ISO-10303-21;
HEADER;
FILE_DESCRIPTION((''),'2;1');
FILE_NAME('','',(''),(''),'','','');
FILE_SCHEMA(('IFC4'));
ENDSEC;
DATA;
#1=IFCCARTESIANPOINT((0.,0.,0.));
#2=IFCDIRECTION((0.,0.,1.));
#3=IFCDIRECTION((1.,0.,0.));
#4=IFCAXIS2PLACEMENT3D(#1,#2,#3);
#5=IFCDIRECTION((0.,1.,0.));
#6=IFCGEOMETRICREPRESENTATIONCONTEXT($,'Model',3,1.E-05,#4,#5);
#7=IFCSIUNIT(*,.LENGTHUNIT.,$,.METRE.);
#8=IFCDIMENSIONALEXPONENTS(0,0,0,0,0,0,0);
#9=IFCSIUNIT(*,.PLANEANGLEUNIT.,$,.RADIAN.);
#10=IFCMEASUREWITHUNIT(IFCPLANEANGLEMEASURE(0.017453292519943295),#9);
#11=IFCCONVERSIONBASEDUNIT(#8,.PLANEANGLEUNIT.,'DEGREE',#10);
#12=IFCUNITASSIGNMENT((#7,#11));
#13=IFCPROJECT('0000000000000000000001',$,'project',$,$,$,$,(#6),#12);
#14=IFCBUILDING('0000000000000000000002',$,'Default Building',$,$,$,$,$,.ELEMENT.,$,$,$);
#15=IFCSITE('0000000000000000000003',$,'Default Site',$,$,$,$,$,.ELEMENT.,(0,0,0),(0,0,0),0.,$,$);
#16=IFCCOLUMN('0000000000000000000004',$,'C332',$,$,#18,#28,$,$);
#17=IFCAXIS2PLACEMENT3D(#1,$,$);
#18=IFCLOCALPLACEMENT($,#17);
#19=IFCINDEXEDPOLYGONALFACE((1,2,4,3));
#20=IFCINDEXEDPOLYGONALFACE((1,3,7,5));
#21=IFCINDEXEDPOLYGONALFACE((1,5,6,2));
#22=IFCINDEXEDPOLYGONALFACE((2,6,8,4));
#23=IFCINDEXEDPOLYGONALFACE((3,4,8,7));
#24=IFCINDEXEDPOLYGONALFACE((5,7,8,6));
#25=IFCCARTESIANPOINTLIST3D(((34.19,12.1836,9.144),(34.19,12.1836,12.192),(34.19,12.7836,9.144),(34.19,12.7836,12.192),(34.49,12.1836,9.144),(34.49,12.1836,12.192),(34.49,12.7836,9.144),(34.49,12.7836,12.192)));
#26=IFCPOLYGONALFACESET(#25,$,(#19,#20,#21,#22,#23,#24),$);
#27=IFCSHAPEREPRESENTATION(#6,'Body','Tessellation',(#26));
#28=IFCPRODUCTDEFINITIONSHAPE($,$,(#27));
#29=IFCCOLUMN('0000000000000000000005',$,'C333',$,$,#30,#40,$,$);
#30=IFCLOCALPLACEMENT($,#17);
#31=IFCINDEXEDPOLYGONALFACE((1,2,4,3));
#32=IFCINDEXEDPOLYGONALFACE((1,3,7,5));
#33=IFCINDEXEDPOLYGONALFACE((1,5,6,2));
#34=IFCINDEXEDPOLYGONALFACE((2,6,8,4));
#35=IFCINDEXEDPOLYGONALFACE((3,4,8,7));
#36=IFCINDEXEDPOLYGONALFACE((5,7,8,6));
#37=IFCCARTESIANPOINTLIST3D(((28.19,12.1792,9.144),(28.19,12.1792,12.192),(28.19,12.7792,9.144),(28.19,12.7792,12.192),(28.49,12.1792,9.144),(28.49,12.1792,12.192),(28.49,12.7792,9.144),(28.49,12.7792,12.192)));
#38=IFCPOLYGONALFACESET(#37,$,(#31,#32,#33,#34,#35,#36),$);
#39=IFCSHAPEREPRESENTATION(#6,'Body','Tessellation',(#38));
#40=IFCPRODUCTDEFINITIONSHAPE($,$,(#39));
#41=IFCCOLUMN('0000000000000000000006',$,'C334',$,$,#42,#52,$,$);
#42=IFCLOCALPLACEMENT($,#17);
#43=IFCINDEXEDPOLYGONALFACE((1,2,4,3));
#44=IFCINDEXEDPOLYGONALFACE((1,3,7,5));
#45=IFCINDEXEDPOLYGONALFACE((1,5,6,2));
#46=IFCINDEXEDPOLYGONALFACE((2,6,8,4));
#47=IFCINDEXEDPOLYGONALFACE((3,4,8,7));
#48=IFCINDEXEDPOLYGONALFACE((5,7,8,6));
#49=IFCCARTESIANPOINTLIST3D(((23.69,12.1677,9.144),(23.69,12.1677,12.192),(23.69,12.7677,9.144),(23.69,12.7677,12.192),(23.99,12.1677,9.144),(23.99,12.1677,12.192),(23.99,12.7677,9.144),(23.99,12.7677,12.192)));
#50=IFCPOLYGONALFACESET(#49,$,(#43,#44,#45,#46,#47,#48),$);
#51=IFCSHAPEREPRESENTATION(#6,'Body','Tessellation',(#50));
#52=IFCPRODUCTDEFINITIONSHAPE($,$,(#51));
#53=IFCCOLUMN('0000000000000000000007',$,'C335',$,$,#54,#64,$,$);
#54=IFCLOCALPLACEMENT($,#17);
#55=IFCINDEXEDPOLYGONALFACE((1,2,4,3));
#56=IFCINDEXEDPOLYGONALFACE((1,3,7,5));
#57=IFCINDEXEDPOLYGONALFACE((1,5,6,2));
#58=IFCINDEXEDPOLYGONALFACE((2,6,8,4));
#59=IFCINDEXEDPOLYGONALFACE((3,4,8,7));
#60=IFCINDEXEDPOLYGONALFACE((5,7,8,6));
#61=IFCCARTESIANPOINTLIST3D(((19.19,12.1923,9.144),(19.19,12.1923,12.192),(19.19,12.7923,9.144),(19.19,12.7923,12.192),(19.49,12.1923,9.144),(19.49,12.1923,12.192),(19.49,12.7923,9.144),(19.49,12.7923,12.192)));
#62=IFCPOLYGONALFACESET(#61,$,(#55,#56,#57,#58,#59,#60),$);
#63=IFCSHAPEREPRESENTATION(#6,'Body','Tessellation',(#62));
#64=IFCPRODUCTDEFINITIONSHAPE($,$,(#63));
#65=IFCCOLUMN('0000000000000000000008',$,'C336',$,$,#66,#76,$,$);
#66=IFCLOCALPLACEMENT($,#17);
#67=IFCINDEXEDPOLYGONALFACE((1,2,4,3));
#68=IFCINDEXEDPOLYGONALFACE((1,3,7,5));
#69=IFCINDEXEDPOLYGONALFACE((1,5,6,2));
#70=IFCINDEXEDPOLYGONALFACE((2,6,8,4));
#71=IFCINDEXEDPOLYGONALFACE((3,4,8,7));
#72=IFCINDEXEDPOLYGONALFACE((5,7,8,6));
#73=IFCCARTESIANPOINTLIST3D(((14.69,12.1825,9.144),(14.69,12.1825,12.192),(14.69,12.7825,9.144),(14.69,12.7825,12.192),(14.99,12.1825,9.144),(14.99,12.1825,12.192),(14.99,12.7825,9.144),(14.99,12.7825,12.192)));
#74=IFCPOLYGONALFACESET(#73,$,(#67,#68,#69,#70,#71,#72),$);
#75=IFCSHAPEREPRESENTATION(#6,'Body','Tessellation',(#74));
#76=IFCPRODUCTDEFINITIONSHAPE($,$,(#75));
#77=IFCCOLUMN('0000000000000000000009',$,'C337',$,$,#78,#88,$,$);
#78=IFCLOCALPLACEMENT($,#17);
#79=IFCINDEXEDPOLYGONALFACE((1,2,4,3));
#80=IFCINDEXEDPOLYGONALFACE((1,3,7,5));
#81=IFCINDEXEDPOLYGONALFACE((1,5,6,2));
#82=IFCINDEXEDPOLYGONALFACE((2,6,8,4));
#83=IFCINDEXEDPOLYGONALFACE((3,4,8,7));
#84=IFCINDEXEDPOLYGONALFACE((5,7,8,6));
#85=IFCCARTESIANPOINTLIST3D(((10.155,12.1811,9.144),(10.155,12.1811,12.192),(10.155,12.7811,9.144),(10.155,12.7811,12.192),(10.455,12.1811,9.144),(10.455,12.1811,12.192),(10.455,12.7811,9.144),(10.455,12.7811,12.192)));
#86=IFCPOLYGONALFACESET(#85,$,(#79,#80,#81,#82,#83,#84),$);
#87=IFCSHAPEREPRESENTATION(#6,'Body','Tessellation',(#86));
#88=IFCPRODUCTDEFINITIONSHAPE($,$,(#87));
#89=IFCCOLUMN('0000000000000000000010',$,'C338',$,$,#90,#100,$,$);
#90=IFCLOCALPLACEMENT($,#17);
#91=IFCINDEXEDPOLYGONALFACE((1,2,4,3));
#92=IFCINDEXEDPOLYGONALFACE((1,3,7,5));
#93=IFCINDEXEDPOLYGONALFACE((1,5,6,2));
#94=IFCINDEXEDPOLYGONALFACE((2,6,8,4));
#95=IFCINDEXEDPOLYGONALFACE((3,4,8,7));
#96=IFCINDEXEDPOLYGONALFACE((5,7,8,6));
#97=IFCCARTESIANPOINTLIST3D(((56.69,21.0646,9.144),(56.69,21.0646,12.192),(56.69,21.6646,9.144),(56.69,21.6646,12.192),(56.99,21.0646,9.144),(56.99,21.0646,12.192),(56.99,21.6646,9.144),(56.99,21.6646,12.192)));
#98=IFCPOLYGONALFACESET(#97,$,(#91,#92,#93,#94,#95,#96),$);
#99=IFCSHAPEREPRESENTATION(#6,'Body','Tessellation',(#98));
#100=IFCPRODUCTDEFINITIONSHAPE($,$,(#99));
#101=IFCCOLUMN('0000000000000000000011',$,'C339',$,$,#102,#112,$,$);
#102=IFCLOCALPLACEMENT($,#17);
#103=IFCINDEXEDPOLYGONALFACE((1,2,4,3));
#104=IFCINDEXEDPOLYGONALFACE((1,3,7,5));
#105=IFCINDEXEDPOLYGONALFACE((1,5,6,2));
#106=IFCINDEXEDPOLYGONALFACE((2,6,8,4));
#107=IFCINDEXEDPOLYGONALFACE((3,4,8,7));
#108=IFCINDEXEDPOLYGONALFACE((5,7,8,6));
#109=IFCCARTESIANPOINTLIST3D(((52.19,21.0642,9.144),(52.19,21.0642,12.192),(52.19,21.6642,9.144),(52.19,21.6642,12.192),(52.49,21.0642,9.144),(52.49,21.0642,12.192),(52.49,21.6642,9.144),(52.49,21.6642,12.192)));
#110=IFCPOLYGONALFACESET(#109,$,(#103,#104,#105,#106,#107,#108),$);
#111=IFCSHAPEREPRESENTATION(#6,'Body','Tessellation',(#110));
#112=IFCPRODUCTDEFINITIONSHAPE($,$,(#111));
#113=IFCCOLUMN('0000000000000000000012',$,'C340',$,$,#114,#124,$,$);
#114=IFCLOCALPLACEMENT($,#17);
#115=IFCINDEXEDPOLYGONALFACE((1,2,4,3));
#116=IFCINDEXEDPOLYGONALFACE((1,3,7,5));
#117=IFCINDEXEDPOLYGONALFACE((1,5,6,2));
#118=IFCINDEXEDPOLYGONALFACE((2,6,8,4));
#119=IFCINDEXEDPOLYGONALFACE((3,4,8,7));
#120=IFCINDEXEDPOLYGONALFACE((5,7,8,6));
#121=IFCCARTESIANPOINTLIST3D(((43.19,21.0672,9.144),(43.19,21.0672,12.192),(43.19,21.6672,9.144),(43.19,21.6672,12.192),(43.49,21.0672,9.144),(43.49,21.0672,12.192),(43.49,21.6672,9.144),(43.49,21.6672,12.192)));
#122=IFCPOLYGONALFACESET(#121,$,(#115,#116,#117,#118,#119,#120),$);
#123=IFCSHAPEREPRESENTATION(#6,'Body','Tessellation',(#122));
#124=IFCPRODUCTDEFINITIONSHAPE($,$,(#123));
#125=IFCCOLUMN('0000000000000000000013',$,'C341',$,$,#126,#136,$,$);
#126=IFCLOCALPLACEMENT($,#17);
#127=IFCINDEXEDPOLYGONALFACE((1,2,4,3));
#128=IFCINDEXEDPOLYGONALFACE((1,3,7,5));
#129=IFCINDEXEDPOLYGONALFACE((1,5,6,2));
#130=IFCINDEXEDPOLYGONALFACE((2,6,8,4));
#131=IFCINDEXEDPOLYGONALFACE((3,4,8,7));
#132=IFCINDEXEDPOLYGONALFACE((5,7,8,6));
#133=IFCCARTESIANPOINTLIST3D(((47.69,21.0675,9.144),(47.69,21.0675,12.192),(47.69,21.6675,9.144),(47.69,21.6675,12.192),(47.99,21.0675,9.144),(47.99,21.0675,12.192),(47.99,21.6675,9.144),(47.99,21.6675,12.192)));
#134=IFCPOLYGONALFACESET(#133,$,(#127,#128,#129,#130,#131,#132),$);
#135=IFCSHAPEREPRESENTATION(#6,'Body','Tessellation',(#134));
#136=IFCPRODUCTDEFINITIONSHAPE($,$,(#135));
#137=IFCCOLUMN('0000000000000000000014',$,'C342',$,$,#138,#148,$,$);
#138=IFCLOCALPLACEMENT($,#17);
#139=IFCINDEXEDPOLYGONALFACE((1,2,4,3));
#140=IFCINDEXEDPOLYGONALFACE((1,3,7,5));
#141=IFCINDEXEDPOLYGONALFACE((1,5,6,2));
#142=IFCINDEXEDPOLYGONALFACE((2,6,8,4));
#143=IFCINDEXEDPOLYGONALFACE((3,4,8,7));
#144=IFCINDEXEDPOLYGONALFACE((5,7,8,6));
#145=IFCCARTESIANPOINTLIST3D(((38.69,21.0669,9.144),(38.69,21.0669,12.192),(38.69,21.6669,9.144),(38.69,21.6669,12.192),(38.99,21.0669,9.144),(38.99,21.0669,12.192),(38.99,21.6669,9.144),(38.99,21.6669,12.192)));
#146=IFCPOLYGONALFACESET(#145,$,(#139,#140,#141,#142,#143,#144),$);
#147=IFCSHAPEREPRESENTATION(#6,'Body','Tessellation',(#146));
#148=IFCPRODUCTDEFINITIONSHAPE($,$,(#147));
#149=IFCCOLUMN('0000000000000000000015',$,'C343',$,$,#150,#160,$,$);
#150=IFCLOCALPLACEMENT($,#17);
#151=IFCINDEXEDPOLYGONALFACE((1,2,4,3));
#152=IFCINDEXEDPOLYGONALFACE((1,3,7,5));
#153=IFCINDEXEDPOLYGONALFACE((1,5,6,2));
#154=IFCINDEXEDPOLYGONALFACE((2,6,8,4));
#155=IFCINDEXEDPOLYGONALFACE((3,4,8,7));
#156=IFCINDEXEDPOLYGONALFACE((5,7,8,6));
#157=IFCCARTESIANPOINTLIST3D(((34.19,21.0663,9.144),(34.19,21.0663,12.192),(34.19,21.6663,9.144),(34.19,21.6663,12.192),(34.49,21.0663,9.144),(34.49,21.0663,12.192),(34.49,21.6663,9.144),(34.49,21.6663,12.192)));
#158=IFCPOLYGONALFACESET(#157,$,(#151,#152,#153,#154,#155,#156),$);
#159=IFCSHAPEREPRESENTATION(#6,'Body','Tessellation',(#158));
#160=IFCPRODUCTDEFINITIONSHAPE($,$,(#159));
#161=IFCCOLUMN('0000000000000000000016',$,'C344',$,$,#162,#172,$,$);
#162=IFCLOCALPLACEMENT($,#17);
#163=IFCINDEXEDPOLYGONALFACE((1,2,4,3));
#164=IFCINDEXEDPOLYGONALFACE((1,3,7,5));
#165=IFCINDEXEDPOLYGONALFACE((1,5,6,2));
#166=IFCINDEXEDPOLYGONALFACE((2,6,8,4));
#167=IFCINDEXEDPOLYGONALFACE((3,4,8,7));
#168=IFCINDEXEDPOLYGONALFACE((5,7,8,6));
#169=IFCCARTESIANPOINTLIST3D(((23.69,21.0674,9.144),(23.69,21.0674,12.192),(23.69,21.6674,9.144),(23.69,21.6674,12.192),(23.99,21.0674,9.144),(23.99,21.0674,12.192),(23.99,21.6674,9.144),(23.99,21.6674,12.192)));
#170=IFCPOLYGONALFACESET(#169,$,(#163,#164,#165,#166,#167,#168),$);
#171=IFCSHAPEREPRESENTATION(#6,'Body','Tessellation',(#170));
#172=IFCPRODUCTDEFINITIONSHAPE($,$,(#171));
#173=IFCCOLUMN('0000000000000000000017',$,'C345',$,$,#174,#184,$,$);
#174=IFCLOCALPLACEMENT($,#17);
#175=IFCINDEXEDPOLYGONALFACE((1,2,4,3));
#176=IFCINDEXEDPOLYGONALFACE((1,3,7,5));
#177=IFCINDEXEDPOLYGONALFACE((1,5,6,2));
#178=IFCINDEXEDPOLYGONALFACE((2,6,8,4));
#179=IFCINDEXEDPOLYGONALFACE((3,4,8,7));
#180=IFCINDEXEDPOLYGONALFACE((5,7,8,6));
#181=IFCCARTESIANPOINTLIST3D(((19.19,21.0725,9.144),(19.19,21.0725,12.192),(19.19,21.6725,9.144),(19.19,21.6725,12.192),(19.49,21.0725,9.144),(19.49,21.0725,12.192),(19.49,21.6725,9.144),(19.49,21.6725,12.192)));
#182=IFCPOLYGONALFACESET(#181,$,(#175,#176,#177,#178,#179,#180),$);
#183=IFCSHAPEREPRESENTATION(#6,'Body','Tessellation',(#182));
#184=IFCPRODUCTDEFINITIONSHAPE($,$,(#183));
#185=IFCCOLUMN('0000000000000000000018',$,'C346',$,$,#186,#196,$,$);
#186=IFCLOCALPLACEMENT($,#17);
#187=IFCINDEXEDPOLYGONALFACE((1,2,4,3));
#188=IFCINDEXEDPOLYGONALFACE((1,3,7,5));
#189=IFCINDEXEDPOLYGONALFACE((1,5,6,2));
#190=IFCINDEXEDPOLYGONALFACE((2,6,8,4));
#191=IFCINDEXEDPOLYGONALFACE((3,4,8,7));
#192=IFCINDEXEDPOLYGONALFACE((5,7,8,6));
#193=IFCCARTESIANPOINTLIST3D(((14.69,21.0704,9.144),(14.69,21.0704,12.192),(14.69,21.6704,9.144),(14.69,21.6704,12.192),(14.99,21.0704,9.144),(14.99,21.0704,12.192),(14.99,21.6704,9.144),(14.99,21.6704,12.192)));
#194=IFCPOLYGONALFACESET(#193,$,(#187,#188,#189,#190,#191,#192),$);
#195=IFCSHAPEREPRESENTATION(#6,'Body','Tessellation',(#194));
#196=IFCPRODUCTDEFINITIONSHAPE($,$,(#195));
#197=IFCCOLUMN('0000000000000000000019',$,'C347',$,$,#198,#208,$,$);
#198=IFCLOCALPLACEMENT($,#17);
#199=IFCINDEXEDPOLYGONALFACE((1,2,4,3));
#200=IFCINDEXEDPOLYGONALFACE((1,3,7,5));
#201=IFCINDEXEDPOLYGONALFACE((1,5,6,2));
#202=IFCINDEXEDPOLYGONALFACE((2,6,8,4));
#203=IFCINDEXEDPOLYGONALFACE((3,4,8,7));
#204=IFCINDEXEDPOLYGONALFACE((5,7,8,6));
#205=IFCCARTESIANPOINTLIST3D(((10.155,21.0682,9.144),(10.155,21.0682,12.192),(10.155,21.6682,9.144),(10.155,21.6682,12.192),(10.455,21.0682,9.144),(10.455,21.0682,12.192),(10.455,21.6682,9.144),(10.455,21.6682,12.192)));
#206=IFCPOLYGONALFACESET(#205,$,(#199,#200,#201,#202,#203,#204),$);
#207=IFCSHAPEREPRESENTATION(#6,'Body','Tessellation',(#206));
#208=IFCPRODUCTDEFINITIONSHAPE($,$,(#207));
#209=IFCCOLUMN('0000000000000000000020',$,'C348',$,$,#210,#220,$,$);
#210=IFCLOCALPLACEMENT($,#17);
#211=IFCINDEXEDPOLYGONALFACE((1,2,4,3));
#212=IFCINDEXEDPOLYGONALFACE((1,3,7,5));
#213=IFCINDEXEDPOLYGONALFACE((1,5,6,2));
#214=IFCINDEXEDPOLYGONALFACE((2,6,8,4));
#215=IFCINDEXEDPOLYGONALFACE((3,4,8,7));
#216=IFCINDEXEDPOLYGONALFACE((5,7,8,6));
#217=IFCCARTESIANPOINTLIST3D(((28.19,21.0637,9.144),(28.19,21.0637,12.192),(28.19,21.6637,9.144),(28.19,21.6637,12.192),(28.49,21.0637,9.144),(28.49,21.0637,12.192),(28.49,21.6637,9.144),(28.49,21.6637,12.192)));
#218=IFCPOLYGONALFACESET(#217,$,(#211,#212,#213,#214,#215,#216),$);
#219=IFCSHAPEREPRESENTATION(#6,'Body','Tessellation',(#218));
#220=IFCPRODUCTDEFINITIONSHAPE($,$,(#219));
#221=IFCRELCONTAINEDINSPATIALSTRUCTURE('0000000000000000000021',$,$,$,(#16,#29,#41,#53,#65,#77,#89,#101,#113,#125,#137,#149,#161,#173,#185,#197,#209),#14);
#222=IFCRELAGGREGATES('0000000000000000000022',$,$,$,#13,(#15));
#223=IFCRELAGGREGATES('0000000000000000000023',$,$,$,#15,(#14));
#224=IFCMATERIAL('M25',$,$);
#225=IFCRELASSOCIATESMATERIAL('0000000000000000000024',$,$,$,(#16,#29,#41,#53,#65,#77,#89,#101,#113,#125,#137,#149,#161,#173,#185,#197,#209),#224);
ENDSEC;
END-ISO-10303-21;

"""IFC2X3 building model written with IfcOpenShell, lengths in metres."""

from ifc_helpers import new_model, entity, si_unit, converted_unit, direction, frame, frame_2d, origin_with_axes, place, context, project, spatial, rectangle, extrude, material, element, save


model = new_model("IFC2X3")

# Units and contexts
model_context = context("Model", 3, precision=1e-05, world=origin_with_axes(), true_north=direction((0.0, 1.0, 0.0)))
ifc_project = project(units=[si_unit("LENGTHUNIT", "METRE"), converted_unit("PLANEANGLEUNIT", "DEGREE", entity("IfcPlaneAngleMeasure", 0.017453292519943295), si_unit("PLANEANGLEUNIT", "RADIAN"), dimensions=[0, 0, 0, 0, 0, 0, 0])], contexts=[model_context])

# Site, building
site = spatial("IfcSite", under=ifc_project, Name="Default Site", CompositionType="ELEMENT", RefLatitude=(0, 0, 0), RefLongitude=(0, 0, 0), RefElevation=0.0)
building = spatial("IfcBuilding", under=site, Name="Default Building", CompositionType="ELEMENT")

# Columns
ifc_material = material(Name="M25")
placement = place(None, origin_with_axes())
element("IfcColumn", 1, at=placement, inside=building, material=ifc_material, Name="C332", context=model_context, shape_type="SweptSolid", body=[
    extrude(rectangle(XDim=0.3, YDim=0.6, at=frame_2d((0.0, 0.0), x_axis=(1.0, 0.0, 0.0))), frame((34.34, 12.4836, 9.144), z_axis=(0.0, 0.0, 1.0), x_axis=(1.0, 0.0, 0.0)), (0.0, 0.0, 1.0), 3.048),
])
element("IfcColumn", 2, at=placement, inside=building, material=ifc_material, Name="C333", context=model_context, shape_type="SweptSolid", body=[
    extrude(rectangle(XDim=0.3, YDim=0.6, at=frame_2d((0.0, 0.0), x_axis=(1.0, 0.0, 0.0))), frame((28.34, 12.4792, 9.144), z_axis=(0.0, 0.0, 1.0), x_axis=(1.0, 0.0, 0.0)), (0.0, 0.0, 1.0), 3.048),
])
element("IfcColumn", 3, at=placement, inside=building, material=ifc_material, Name="C334", context=model_context, shape_type="SweptSolid", body=[
    extrude(rectangle(XDim=0.3, YDim=0.6, at=frame_2d((0.0, 0.0), x_axis=(1.0, 0.0, 0.0))), frame((23.84, 12.4677, 9.144), z_axis=(0.0, 0.0, 1.0), x_axis=(1.0, 0.0, 0.0)), (0.0, 0.0, 1.0), 3.048),
])
element("IfcColumn", 4, at=placement, inside=building, material=ifc_material, Name="C335", context=model_context, shape_type="SweptSolid", body=[
    extrude(rectangle(XDim=0.3, YDim=0.6, at=frame_2d((0.0, 0.0), x_axis=(1.0, 0.0, 0.0))), frame((19.34, 12.4923, 9.144), z_axis=(0.0, 0.0, 1.0), x_axis=(1.0, 0.0, 0.0)), (0.0, 0.0, 1.0), 3.048),
])
element("IfcColumn", 5, at=placement, inside=building, material=ifc_material, Name="C336", context=model_context, shape_type="SweptSolid", body=[
    extrude(rectangle(XDim=0.3, YDim=0.6, at=frame_2d((0.0, 0.0), x_axis=(1.0, 0.0, 0.0))), frame((14.84, 12.4825, 9.144), z_axis=(0.0, 0.0, 1.0), x_axis=(1.0, 0.0, 0.0)), (0.0, 0.0, 1.0), 3.048),
])
element("IfcColumn", 6, at=placement, inside=building, material=ifc_material, Name="C337", context=model_context, shape_type="SweptSolid", body=[
    extrude(rectangle(XDim=0.3, YDim=0.6, at=frame_2d((0.0, 0.0), x_axis=(1.0, 0.0, 0.0))), frame((10.305, 12.4811, 9.144), z_axis=(0.0, 0.0, 1.0), x_axis=(1.0, 0.0, 0.0)), (0.0, 0.0, 1.0), 3.048),
])
element("IfcColumn", 7, at=placement, inside=building, material=ifc_material, Name="C338", context=model_context, shape_type="SweptSolid", body=[
    extrude(rectangle(XDim=0.3, YDim=0.6, at=frame_2d((0.0, 0.0), x_axis=(1.0, 0.0, 0.0))), frame((56.84, 21.3646, 9.144), z_axis=(0.0, 0.0, 1.0), x_axis=(1.0, 0.0, 0.0)), (0.0, 0.0, 1.0), 3.048),
])
element("IfcColumn", 8, at=placement, inside=building, material=ifc_material, Name="C339", context=model_context, shape_type="SweptSolid", body=[
    extrude(rectangle(XDim=0.3, YDim=0.6, at=frame_2d((0.0, 0.0), x_axis=(1.0, 0.0, 0.0))), frame((52.34, 21.3642, 9.144), z_axis=(0.0, 0.0, 1.0), x_axis=(1.0, 0.0, 0.0)), (0.0, 0.0, 1.0), 3.048),
])
element("IfcColumn", 9, at=placement, inside=building, material=ifc_material, Name="C340", context=model_context, shape_type="SweptSolid", body=[
    extrude(rectangle(XDim=0.3, YDim=0.6, at=frame_2d((0.0, 0.0), x_axis=(1.0, 0.0, 0.0))), frame((43.34, 21.3672, 9.144), z_axis=(0.0, 0.0, 1.0), x_axis=(1.0, 0.0, 0.0)), (0.0, 0.0, 1.0), 3.048),
])
element("IfcColumn", 10, at=placement, inside=building, material=ifc_material, Name="C341", context=model_context, shape_type="SweptSolid", body=[
    extrude(rectangle(XDim=0.3, YDim=0.6, at=frame_2d((0.0, 0.0), x_axis=(1.0, 0.0, 0.0))), frame((47.84, 21.3675, 9.144), z_axis=(0.0, 0.0, 1.0), x_axis=(1.0, 0.0, 0.0)), (0.0, 0.0, 1.0), 3.048),
])
element("IfcColumn", 11, at=placement, inside=building, material=ifc_material, Name="C342", context=model_context, shape_type="SweptSolid", body=[
    extrude(rectangle(XDim=0.3, YDim=0.6, at=frame_2d((0.0, 0.0), x_axis=(1.0, 0.0, 0.0))), frame((38.84, 21.3669, 9.144), z_axis=(0.0, 0.0, 1.0), x_axis=(1.0, 0.0, 0.0)), (0.0, 0.0, 1.0), 3.048),
])
element("IfcColumn", 12, at=placement, inside=building, material=ifc_material, Name="C343", context=model_context, shape_type="SweptSolid", body=[
    extrude(rectangle(XDim=0.3, YDim=0.6, at=frame_2d((0.0, 0.0), x_axis=(1.0, 0.0, 0.0))), frame((34.34, 21.3663, 9.144), z_axis=(0.0, 0.0, 1.0), x_axis=(1.0, 0.0, 0.0)), (0.0, 0.0, 1.0), 3.048),
])
element("IfcColumn", 13, at=placement, inside=building, material=ifc_material, Name="C344", context=model_context, shape_type="SweptSolid", body=[
    extrude(rectangle(XDim=0.3, YDim=0.6, at=frame_2d((0.0, 0.0), x_axis=(1.0, 0.0, 0.0))), frame((23.84, 21.3674, 9.144), z_axis=(0.0, 0.0, 1.0), x_axis=(1.0, 0.0, 0.0)), (0.0, 0.0, 1.0), 3.048),
])
element("IfcColumn", 14, at=placement, inside=building, material=ifc_material, Name="C345", context=model_context, shape_type="SweptSolid", body=[
    extrude(rectangle(XDim=0.3, YDim=0.6, at=frame_2d((0.0, 0.0), x_axis=(1.0, 0.0, 0.0))), frame((19.34, 21.3725, 9.144), z_axis=(0.0, 0.0, 1.0), x_axis=(1.0, 0.0, 0.0)), (0.0, 0.0, 1.0), 3.048),
])
element("IfcColumn", 15, at=placement, inside=building, material=ifc_material, Name="C346", context=model_context, shape_type="SweptSolid", body=[
    extrude(rectangle(XDim=0.3, YDim=0.6, at=frame_2d((0.0, 0.0), x_axis=(1.0, 0.0, 0.0))), frame((14.84, 21.3704, 9.144), z_axis=(0.0, 0.0, 1.0), x_axis=(1.0, 0.0, 0.0)), (0.0, 0.0, 1.0), 3.048),
])
element("IfcColumn", 16, at=placement, inside=building, material=ifc_material, Name="C347", context=model_context, shape_type="SweptSolid", body=[
    extrude(rectangle(XDim=0.3, YDim=0.6, at=frame_2d((0.0, 0.0), x_axis=(1.0, 0.0, 0.0))), frame((10.305, 21.3682, 9.144), z_axis=(0.0, 0.0, 1.0), x_axis=(1.0, 0.0, 0.0)), (0.0, 0.0, 1.0), 3.048),
])
element("IfcColumn", 17, at=placement, inside=building, material=ifc_material, Name="C348", context=model_context, shape_type="SweptSolid", body=[
    extrude(rectangle(XDim=0.3, YDim=0.6, at=frame_2d((0.0, 0.0), x_axis=(1.0, 0.0, 0.0))), frame((28.34, 21.3637, 9.144), z_axis=(0.0, 0.0, 1.0), x_axis=(1.0, 0.0, 0.0)), (0.0, 0.0, 1.0), 3.048),
])

save(model, "model.ifc")
